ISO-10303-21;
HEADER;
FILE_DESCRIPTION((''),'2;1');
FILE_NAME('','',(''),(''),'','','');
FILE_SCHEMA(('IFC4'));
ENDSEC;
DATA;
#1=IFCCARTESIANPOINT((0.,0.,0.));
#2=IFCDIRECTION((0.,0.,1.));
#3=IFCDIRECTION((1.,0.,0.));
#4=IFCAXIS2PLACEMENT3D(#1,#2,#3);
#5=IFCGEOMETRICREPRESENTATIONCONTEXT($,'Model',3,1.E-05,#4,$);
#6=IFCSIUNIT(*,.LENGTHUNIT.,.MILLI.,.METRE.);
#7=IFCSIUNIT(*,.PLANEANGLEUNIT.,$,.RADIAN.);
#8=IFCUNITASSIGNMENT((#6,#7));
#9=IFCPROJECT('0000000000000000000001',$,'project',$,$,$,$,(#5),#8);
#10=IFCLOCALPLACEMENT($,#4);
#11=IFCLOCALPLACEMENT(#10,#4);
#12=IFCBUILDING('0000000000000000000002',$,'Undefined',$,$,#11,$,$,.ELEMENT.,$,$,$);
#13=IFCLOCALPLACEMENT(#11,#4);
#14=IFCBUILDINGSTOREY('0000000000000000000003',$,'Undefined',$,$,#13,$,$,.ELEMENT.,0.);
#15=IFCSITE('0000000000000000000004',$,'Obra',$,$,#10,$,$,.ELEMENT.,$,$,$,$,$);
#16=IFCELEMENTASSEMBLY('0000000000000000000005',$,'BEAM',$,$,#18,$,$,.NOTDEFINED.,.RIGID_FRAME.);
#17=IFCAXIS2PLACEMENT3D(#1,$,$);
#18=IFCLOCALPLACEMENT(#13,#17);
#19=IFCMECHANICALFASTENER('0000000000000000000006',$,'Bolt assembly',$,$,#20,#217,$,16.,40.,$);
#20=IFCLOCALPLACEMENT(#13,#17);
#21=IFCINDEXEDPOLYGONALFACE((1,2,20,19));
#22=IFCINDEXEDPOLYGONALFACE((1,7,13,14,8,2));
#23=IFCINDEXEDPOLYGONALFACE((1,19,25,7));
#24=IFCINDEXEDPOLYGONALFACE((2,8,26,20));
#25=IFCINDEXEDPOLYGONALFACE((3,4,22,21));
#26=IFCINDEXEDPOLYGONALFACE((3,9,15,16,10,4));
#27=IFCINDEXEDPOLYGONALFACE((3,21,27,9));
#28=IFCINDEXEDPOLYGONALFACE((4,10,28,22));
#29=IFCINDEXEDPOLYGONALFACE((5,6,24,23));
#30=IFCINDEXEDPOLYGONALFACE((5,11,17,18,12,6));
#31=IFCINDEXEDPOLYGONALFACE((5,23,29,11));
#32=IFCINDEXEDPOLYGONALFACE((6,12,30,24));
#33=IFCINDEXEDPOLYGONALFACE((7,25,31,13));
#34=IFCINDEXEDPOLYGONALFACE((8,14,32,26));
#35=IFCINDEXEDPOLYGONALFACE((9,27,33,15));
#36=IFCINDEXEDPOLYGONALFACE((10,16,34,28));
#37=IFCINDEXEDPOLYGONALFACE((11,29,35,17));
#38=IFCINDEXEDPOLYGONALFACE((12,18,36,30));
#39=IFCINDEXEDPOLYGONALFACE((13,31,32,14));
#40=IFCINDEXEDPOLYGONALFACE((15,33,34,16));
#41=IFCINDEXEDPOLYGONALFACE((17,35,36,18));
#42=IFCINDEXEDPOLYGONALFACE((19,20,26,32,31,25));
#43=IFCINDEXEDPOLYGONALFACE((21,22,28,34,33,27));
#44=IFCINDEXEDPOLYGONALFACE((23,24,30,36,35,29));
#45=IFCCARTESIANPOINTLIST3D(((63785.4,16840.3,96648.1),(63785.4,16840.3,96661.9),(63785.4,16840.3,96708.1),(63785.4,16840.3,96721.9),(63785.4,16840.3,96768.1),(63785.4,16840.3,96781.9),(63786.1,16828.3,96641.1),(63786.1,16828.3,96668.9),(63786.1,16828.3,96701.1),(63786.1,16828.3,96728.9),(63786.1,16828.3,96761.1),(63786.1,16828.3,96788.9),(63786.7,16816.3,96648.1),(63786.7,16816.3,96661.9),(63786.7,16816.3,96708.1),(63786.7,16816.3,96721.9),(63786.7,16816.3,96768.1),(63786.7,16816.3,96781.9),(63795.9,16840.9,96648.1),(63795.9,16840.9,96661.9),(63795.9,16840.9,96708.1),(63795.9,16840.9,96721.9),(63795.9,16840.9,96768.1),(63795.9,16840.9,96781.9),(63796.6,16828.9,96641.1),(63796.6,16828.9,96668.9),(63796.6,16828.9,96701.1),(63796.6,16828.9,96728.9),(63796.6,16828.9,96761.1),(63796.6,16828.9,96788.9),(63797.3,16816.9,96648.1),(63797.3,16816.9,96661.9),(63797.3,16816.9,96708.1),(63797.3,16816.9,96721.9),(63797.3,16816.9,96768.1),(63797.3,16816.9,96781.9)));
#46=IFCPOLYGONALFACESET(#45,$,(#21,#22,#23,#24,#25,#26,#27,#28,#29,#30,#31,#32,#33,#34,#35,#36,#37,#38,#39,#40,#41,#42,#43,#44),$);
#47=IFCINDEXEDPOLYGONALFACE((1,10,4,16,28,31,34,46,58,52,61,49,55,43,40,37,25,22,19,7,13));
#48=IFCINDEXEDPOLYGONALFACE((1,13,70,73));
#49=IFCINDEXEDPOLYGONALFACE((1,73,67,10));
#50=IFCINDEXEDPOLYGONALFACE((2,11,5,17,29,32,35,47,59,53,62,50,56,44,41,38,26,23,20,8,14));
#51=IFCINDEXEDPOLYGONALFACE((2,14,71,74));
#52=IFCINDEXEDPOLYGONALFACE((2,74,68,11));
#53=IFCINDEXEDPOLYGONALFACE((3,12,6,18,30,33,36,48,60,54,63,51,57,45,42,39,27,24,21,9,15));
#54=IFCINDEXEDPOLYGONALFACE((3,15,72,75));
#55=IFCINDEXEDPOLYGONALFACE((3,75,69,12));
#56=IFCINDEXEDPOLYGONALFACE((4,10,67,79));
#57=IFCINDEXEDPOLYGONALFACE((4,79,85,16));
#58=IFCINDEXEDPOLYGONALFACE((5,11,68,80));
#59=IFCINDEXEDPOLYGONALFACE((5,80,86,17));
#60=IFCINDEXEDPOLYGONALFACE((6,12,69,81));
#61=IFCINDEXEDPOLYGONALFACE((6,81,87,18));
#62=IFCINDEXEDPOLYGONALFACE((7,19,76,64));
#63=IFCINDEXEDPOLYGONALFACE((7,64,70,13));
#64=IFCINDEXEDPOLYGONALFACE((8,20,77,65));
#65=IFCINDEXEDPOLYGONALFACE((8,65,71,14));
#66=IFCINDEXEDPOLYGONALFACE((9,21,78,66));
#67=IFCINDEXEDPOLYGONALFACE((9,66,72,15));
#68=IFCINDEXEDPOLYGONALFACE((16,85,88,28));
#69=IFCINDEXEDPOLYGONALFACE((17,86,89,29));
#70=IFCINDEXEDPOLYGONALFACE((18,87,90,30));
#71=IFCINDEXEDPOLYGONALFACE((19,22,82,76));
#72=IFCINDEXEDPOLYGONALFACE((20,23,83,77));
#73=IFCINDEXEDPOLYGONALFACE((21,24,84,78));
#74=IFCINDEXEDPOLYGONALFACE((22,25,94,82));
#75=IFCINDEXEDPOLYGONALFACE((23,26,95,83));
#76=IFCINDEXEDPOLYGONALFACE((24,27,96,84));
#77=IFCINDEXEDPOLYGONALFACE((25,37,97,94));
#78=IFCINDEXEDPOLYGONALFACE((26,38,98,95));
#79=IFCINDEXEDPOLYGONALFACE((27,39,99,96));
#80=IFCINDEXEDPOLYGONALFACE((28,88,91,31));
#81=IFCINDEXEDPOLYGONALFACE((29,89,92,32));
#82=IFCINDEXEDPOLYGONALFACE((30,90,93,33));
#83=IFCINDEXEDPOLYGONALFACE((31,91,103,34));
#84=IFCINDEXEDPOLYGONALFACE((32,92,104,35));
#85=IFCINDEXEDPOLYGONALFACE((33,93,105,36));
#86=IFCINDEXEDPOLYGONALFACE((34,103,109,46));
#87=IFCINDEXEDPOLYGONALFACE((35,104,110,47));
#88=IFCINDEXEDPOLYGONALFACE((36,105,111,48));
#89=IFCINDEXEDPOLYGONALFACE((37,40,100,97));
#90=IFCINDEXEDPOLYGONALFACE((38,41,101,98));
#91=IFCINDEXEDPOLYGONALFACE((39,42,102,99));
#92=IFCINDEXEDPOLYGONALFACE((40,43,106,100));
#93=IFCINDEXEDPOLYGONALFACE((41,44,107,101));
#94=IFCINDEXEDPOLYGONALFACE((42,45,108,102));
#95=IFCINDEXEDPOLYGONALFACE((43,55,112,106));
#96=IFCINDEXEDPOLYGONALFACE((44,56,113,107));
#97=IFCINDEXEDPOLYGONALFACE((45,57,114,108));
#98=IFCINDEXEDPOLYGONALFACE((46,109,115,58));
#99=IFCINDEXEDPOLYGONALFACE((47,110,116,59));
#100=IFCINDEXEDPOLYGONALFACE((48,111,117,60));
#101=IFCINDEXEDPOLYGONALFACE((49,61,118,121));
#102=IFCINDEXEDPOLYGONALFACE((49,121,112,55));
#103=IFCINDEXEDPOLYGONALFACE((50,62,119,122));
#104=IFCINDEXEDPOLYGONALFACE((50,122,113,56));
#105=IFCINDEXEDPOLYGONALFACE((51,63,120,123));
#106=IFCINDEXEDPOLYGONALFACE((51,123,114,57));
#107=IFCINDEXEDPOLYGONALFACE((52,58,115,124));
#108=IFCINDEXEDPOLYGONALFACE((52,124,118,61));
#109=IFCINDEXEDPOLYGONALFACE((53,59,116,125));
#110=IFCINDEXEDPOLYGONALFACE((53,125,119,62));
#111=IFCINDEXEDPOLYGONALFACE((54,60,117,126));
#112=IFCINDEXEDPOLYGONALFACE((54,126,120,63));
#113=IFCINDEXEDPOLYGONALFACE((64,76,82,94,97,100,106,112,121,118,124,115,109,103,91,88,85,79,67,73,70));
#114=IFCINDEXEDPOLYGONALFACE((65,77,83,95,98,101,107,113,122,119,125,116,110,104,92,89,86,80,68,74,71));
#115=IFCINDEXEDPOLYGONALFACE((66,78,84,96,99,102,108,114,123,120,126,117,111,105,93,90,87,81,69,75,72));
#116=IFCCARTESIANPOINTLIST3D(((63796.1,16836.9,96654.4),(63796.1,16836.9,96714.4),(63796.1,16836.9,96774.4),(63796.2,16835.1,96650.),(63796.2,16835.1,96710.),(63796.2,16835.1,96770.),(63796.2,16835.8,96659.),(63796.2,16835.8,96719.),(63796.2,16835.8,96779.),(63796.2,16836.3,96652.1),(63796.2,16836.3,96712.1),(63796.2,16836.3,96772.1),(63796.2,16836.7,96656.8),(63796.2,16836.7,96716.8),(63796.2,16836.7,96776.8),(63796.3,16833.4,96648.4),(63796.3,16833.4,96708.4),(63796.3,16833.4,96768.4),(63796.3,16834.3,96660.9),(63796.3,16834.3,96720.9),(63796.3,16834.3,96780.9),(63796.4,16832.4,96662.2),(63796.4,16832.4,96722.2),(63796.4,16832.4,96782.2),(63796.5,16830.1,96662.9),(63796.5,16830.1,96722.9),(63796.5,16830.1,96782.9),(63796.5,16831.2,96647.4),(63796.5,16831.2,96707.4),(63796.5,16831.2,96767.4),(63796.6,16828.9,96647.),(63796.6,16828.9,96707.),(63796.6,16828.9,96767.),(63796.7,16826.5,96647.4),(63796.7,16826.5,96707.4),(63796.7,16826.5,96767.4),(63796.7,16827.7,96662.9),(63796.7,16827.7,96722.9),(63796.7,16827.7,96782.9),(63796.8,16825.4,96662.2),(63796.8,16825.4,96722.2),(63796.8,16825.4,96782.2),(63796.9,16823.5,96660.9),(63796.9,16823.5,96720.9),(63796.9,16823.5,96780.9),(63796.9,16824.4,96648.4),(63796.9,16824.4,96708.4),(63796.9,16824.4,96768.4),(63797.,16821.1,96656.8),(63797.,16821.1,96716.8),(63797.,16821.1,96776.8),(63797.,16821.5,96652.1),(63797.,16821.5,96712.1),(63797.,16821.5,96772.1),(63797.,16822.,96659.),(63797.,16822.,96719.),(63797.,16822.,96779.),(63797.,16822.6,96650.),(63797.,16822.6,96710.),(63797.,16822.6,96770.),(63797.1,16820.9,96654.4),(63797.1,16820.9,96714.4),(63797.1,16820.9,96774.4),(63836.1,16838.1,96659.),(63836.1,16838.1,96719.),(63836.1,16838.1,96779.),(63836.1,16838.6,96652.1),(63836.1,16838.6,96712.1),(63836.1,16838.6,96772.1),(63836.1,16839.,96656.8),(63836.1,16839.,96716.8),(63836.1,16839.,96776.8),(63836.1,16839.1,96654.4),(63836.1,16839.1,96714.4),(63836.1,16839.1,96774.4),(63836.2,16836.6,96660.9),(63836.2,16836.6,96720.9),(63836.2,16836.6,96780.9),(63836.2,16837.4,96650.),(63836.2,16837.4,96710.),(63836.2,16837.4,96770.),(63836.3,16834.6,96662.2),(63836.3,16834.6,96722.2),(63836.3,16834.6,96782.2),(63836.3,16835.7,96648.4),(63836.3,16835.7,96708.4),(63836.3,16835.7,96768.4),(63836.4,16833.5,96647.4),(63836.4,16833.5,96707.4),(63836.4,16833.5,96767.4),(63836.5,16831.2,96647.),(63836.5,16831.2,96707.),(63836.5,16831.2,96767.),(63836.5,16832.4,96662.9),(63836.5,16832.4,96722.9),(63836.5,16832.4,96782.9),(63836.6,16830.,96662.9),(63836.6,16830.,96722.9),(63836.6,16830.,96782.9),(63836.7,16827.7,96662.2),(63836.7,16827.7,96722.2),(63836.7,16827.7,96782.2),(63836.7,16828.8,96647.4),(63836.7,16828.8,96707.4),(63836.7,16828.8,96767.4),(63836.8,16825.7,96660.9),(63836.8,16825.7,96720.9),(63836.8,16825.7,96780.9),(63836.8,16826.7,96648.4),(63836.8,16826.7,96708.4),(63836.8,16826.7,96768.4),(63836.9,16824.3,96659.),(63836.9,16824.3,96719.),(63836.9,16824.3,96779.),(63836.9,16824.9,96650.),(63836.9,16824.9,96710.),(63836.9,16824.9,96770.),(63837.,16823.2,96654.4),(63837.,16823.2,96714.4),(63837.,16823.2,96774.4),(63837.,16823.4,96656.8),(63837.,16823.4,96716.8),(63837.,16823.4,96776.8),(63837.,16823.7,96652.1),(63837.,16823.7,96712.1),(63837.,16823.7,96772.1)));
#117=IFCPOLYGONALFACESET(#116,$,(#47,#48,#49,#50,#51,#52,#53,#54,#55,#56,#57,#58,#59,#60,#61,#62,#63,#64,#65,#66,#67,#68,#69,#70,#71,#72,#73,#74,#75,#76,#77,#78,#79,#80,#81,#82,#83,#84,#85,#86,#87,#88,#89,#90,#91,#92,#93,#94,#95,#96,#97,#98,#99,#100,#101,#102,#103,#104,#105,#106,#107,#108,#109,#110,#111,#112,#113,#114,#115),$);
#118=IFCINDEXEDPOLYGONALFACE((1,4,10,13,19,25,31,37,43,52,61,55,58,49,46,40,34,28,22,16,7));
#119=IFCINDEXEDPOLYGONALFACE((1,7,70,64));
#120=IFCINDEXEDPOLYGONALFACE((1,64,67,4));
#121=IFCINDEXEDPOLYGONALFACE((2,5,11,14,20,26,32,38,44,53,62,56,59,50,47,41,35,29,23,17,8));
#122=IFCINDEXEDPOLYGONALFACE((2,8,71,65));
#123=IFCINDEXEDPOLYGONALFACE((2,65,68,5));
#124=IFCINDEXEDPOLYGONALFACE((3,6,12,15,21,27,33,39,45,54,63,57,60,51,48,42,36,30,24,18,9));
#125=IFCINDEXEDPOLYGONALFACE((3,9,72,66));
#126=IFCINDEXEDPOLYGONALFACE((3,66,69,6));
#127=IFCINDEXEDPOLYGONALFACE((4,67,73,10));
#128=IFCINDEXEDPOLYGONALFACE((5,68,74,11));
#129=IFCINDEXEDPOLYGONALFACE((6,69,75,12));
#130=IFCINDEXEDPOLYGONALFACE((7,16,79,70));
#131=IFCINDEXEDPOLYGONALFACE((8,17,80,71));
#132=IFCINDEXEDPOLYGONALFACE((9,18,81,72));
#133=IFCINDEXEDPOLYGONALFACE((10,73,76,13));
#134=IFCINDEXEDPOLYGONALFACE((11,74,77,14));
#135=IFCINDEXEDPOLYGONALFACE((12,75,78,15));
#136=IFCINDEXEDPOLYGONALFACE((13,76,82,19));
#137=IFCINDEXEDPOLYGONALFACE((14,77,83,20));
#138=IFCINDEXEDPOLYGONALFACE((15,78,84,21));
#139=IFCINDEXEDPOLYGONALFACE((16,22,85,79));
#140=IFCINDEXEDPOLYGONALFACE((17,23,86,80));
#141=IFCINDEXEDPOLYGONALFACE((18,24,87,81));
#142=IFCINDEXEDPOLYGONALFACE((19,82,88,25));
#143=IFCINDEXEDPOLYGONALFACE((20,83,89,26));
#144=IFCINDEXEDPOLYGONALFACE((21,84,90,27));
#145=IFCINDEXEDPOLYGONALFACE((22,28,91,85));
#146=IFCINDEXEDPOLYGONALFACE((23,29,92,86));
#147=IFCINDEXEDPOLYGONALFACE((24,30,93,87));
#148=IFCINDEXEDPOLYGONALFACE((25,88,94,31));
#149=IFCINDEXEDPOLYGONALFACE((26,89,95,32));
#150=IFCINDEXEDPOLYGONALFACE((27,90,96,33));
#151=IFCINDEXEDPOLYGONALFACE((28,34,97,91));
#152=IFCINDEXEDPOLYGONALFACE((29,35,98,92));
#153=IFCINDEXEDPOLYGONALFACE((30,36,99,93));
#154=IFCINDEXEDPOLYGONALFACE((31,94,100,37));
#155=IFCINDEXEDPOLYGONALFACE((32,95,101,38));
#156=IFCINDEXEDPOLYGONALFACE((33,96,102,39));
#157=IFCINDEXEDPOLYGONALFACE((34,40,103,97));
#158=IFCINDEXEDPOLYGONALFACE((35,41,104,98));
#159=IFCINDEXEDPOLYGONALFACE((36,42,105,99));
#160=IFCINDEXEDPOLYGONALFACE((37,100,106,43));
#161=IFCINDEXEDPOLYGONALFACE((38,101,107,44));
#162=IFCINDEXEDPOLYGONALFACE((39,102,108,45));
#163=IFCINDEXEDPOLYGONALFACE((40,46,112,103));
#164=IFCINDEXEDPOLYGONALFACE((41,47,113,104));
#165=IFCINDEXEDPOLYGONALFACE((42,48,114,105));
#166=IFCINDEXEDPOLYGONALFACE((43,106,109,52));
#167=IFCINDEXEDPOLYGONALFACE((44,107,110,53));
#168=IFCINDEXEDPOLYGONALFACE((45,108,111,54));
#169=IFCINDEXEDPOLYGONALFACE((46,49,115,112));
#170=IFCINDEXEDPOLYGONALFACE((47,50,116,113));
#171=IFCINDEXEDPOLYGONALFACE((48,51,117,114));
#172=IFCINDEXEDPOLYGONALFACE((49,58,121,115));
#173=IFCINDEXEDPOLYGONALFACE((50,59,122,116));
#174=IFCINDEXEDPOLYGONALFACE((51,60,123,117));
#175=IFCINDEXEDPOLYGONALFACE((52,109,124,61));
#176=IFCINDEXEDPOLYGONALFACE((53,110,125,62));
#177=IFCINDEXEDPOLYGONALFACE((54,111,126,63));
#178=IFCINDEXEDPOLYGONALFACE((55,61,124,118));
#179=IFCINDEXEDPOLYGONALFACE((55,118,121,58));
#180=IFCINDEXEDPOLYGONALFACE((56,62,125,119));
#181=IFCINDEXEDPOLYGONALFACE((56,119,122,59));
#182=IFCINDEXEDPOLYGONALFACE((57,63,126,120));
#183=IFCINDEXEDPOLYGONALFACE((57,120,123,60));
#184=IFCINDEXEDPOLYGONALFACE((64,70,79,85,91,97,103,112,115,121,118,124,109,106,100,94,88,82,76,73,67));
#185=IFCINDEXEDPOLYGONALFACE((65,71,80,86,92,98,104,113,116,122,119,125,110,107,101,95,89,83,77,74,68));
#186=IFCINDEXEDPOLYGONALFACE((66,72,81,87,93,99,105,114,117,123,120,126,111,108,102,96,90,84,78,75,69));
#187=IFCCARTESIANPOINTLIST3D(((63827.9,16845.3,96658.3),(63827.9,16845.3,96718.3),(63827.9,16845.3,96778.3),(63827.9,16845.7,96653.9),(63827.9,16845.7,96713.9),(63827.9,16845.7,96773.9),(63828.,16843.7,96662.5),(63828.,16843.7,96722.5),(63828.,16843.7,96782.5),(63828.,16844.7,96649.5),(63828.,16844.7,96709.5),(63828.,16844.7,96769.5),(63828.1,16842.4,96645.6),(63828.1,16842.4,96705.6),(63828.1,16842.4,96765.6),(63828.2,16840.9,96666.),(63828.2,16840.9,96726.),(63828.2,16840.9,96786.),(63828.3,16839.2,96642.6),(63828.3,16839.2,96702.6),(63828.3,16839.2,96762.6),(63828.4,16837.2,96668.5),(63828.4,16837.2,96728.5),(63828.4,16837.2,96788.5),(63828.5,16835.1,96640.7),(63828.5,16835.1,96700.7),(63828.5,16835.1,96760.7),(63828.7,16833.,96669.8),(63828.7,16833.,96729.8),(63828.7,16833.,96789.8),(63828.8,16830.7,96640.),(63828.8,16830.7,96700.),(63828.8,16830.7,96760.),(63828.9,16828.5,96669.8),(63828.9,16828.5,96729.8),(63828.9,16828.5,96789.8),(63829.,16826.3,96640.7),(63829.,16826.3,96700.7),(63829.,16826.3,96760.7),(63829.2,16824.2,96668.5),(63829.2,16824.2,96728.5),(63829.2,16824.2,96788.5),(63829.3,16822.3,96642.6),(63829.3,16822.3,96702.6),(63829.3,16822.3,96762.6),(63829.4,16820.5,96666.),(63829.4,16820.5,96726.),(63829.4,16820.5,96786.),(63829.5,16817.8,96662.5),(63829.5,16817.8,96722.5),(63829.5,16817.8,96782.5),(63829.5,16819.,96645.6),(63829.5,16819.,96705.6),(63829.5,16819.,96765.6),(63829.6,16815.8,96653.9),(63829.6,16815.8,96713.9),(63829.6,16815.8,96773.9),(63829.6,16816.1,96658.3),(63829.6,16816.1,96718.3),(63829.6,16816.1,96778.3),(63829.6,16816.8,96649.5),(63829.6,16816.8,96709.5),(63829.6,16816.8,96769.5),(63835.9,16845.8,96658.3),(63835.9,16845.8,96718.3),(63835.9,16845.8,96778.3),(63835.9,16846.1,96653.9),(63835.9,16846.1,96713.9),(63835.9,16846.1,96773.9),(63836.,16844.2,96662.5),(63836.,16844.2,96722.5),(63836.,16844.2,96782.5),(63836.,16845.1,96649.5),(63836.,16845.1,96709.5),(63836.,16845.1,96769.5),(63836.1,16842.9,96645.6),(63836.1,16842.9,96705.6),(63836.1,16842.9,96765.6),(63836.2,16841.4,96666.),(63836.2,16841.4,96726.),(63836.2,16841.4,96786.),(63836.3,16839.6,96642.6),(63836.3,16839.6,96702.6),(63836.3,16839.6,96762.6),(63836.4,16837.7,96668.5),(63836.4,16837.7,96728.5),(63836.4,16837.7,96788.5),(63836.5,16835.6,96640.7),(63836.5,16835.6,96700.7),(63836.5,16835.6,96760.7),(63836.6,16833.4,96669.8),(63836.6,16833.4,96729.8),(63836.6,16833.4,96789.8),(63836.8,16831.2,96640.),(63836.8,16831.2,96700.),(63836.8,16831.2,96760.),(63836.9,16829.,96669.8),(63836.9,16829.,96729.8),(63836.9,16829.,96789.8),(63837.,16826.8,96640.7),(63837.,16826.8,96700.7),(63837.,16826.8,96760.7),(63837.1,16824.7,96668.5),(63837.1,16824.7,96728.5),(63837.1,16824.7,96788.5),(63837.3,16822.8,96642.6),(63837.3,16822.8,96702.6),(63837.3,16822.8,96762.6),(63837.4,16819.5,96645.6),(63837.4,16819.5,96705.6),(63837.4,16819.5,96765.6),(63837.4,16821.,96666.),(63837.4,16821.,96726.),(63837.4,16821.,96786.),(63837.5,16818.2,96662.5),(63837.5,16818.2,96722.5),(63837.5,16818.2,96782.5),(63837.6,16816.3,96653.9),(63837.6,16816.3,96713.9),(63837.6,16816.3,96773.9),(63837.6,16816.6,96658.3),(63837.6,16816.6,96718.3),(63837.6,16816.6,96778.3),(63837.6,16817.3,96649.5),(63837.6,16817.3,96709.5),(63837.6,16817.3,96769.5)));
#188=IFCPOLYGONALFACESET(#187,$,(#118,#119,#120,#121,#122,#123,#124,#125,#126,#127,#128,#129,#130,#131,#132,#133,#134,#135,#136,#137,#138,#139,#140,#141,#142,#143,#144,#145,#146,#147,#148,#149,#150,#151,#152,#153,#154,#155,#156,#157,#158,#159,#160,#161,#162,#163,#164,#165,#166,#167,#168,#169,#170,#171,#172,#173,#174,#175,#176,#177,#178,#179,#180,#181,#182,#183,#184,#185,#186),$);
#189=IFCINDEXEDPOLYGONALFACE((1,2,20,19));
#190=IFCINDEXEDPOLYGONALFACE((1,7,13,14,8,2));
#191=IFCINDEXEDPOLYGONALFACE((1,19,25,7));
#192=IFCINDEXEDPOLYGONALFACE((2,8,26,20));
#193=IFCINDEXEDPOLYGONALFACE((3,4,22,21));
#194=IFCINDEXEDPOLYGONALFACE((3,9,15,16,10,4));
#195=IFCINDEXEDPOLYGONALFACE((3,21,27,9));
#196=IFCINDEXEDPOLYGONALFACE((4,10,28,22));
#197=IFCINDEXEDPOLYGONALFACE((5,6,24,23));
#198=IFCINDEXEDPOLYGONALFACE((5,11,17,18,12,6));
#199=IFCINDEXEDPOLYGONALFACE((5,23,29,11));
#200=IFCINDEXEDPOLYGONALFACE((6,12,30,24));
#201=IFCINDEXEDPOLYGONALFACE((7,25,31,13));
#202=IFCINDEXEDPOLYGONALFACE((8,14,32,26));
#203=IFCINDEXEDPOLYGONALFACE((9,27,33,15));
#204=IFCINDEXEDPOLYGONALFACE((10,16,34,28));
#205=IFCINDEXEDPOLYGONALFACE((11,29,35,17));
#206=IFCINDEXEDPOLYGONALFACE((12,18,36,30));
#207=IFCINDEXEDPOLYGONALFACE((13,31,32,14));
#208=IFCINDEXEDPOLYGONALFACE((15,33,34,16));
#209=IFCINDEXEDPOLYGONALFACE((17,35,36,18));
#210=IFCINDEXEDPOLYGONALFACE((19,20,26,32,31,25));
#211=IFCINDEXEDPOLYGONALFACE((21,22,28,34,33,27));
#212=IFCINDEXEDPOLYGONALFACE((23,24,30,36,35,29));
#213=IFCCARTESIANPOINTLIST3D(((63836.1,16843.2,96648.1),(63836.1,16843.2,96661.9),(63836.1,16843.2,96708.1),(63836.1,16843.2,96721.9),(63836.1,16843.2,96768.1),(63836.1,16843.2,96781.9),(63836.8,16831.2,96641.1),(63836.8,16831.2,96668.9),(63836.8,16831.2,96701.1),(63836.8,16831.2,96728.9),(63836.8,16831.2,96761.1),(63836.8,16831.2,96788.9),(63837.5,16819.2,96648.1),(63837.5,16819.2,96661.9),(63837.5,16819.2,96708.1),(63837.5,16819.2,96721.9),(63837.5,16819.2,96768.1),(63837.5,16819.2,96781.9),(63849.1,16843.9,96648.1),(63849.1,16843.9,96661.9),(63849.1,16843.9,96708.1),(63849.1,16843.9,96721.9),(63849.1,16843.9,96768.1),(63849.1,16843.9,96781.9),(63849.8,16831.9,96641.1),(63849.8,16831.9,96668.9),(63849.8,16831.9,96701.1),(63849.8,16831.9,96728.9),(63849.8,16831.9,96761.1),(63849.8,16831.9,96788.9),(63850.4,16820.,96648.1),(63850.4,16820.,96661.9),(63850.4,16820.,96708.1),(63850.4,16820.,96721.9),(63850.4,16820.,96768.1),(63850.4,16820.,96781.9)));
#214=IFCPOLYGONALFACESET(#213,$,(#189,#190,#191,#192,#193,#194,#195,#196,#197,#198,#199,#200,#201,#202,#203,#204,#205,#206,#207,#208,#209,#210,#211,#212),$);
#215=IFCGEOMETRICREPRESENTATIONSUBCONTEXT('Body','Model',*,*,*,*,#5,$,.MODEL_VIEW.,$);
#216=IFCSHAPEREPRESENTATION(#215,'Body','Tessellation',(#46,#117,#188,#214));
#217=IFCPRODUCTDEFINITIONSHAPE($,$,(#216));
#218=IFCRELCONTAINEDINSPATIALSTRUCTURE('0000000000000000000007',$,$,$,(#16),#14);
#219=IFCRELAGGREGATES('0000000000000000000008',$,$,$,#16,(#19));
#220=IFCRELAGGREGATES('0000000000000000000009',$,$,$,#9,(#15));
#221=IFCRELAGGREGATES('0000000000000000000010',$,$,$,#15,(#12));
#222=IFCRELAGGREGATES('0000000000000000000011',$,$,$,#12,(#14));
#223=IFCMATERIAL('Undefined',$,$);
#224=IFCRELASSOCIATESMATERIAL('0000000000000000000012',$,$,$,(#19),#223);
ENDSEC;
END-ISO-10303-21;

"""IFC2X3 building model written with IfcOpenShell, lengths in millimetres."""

from ifc_helpers import new_model, si_unit, frame, origin_with_axes, origin_2d_with_axis, place, context, subcontext, project, spatial, polyline, circle, outline, extrude, source, transform, mapped, material, element, aggregate, save


model = new_model("IFC2X3")

# Units and contexts
model_context = context("Model", 3, precision=1e-05, world=origin_with_axes())
body_context = subcontext(model_context, "Body", "Model", "MODEL_VIEW")
ifc_project = project(units=[si_unit("LENGTHUNIT", "METRE", prefix="MILLI"), si_unit("PLANEANGLEUNIT", "RADIAN")], contexts=[model_context])

# Site, building, storey
site_placement = place(None, origin_with_axes())
site = spatial("IfcSite", under=ifc_project, at=site_placement, Name="Obra", CompositionType="ELEMENT")
building_placement = place(site_placement, origin_with_axes())
building = spatial("IfcBuilding", under=site, at=building_placement, Name="Undefined", CompositionType="ELEMENT")
storey_placement = place(building_placement, origin_with_axes())
storey = spatial("IfcBuildingStorey", under=building, at=storey_placement, Name="Undefined", CompositionType="ELEMENT", Elevation=0.0)

# Shared definitions
ifc_material_1 = material(Name="Undefined")

# Element assembly, mechanical fastener
assembly_1_placement = place(storey_placement, origin_with_axes())
assembly_1 = element("IfcElementAssembly", 1, at=assembly_1_placement, inside=storey, Name="BEAM", AssemblyPlace="NOTDEFINED", PredefinedType="RIGID_FRAME")
shared_shape_1 = source(origin_with_axes(), body_context, "Body", "SweptSolid", [
    extrude(outline(polyline([(13.9, 0.0), (6.9, 12.0), (-6.9, 12.0), (-13.9, 0.0), (-6.9, -12.0), (6.9, -12.0), (13.9, 0.0)])), frame((0.0, -45.9, 0.0), z_axis=(0.0, 1.0, 0.0), x_axis=(1.0, 0.0, 0.0)), (0.0, 0.0, 1.0), 10.6),
    extrude(circle(Radius=8.0, at=origin_2d_with_axis()), frame((0.0, -35.3, 0.0), z_axis=(0.0, 1.0, 0.0), x_axis=(1.0, 0.0, 0.0)), (0.0, 0.0, 1.0), 40.0),
    extrude(circle(Radius=15.0, at=origin_2d_with_axis()), frame((0.0, -3.1, 0.0), z_axis=(0.0, 1.0, 0.0), x_axis=(1.0, 0.0, 0.0)), (0.0, 0.0, 1.0), 8.0),
    extrude(outline(polyline([(13.9, 0.0), (6.9, 12.0), (-6.9, 12.0), (-13.9, 0.0), (-6.9, -12.0), (6.9, -12.0), (13.9, 0.0)])), frame((0.0, 4.9, 0.0), z_axis=(0.0, 1.0, 0.0), x_axis=(1.0, 0.0, 0.0)), (0.0, 0.0, 1.0), 13.0),
])
mechanical_fastener_1_placement = place(assembly_1_placement, frame((63829.0, 16880.8, 96835.0), z_axis=(0.057107, -0.998368, 0.0), x_axis=(0.0, 0.0, -1.0)))
mechanical_fastener_1 = element("IfcMechanicalFastener", 2, at=mechanical_fastener_1_placement, material=ifc_material_1, Name="Bolt assembly", NominalDiameter=16.0, NominalLength=40.0, context=body_context, shape_type="MappedRepresentation", body=[
    mapped(shared_shape_1, transform((60.0, 0.0, 50.0))),
    mapped(shared_shape_1, transform((120.0, 0.0, 50.0))),
    mapped(shared_shape_1, transform((180.0, 0.0, 50.0))),
])
aggregate(assembly_1, [mechanical_fastener_1])

save(model, "model.ifc")
